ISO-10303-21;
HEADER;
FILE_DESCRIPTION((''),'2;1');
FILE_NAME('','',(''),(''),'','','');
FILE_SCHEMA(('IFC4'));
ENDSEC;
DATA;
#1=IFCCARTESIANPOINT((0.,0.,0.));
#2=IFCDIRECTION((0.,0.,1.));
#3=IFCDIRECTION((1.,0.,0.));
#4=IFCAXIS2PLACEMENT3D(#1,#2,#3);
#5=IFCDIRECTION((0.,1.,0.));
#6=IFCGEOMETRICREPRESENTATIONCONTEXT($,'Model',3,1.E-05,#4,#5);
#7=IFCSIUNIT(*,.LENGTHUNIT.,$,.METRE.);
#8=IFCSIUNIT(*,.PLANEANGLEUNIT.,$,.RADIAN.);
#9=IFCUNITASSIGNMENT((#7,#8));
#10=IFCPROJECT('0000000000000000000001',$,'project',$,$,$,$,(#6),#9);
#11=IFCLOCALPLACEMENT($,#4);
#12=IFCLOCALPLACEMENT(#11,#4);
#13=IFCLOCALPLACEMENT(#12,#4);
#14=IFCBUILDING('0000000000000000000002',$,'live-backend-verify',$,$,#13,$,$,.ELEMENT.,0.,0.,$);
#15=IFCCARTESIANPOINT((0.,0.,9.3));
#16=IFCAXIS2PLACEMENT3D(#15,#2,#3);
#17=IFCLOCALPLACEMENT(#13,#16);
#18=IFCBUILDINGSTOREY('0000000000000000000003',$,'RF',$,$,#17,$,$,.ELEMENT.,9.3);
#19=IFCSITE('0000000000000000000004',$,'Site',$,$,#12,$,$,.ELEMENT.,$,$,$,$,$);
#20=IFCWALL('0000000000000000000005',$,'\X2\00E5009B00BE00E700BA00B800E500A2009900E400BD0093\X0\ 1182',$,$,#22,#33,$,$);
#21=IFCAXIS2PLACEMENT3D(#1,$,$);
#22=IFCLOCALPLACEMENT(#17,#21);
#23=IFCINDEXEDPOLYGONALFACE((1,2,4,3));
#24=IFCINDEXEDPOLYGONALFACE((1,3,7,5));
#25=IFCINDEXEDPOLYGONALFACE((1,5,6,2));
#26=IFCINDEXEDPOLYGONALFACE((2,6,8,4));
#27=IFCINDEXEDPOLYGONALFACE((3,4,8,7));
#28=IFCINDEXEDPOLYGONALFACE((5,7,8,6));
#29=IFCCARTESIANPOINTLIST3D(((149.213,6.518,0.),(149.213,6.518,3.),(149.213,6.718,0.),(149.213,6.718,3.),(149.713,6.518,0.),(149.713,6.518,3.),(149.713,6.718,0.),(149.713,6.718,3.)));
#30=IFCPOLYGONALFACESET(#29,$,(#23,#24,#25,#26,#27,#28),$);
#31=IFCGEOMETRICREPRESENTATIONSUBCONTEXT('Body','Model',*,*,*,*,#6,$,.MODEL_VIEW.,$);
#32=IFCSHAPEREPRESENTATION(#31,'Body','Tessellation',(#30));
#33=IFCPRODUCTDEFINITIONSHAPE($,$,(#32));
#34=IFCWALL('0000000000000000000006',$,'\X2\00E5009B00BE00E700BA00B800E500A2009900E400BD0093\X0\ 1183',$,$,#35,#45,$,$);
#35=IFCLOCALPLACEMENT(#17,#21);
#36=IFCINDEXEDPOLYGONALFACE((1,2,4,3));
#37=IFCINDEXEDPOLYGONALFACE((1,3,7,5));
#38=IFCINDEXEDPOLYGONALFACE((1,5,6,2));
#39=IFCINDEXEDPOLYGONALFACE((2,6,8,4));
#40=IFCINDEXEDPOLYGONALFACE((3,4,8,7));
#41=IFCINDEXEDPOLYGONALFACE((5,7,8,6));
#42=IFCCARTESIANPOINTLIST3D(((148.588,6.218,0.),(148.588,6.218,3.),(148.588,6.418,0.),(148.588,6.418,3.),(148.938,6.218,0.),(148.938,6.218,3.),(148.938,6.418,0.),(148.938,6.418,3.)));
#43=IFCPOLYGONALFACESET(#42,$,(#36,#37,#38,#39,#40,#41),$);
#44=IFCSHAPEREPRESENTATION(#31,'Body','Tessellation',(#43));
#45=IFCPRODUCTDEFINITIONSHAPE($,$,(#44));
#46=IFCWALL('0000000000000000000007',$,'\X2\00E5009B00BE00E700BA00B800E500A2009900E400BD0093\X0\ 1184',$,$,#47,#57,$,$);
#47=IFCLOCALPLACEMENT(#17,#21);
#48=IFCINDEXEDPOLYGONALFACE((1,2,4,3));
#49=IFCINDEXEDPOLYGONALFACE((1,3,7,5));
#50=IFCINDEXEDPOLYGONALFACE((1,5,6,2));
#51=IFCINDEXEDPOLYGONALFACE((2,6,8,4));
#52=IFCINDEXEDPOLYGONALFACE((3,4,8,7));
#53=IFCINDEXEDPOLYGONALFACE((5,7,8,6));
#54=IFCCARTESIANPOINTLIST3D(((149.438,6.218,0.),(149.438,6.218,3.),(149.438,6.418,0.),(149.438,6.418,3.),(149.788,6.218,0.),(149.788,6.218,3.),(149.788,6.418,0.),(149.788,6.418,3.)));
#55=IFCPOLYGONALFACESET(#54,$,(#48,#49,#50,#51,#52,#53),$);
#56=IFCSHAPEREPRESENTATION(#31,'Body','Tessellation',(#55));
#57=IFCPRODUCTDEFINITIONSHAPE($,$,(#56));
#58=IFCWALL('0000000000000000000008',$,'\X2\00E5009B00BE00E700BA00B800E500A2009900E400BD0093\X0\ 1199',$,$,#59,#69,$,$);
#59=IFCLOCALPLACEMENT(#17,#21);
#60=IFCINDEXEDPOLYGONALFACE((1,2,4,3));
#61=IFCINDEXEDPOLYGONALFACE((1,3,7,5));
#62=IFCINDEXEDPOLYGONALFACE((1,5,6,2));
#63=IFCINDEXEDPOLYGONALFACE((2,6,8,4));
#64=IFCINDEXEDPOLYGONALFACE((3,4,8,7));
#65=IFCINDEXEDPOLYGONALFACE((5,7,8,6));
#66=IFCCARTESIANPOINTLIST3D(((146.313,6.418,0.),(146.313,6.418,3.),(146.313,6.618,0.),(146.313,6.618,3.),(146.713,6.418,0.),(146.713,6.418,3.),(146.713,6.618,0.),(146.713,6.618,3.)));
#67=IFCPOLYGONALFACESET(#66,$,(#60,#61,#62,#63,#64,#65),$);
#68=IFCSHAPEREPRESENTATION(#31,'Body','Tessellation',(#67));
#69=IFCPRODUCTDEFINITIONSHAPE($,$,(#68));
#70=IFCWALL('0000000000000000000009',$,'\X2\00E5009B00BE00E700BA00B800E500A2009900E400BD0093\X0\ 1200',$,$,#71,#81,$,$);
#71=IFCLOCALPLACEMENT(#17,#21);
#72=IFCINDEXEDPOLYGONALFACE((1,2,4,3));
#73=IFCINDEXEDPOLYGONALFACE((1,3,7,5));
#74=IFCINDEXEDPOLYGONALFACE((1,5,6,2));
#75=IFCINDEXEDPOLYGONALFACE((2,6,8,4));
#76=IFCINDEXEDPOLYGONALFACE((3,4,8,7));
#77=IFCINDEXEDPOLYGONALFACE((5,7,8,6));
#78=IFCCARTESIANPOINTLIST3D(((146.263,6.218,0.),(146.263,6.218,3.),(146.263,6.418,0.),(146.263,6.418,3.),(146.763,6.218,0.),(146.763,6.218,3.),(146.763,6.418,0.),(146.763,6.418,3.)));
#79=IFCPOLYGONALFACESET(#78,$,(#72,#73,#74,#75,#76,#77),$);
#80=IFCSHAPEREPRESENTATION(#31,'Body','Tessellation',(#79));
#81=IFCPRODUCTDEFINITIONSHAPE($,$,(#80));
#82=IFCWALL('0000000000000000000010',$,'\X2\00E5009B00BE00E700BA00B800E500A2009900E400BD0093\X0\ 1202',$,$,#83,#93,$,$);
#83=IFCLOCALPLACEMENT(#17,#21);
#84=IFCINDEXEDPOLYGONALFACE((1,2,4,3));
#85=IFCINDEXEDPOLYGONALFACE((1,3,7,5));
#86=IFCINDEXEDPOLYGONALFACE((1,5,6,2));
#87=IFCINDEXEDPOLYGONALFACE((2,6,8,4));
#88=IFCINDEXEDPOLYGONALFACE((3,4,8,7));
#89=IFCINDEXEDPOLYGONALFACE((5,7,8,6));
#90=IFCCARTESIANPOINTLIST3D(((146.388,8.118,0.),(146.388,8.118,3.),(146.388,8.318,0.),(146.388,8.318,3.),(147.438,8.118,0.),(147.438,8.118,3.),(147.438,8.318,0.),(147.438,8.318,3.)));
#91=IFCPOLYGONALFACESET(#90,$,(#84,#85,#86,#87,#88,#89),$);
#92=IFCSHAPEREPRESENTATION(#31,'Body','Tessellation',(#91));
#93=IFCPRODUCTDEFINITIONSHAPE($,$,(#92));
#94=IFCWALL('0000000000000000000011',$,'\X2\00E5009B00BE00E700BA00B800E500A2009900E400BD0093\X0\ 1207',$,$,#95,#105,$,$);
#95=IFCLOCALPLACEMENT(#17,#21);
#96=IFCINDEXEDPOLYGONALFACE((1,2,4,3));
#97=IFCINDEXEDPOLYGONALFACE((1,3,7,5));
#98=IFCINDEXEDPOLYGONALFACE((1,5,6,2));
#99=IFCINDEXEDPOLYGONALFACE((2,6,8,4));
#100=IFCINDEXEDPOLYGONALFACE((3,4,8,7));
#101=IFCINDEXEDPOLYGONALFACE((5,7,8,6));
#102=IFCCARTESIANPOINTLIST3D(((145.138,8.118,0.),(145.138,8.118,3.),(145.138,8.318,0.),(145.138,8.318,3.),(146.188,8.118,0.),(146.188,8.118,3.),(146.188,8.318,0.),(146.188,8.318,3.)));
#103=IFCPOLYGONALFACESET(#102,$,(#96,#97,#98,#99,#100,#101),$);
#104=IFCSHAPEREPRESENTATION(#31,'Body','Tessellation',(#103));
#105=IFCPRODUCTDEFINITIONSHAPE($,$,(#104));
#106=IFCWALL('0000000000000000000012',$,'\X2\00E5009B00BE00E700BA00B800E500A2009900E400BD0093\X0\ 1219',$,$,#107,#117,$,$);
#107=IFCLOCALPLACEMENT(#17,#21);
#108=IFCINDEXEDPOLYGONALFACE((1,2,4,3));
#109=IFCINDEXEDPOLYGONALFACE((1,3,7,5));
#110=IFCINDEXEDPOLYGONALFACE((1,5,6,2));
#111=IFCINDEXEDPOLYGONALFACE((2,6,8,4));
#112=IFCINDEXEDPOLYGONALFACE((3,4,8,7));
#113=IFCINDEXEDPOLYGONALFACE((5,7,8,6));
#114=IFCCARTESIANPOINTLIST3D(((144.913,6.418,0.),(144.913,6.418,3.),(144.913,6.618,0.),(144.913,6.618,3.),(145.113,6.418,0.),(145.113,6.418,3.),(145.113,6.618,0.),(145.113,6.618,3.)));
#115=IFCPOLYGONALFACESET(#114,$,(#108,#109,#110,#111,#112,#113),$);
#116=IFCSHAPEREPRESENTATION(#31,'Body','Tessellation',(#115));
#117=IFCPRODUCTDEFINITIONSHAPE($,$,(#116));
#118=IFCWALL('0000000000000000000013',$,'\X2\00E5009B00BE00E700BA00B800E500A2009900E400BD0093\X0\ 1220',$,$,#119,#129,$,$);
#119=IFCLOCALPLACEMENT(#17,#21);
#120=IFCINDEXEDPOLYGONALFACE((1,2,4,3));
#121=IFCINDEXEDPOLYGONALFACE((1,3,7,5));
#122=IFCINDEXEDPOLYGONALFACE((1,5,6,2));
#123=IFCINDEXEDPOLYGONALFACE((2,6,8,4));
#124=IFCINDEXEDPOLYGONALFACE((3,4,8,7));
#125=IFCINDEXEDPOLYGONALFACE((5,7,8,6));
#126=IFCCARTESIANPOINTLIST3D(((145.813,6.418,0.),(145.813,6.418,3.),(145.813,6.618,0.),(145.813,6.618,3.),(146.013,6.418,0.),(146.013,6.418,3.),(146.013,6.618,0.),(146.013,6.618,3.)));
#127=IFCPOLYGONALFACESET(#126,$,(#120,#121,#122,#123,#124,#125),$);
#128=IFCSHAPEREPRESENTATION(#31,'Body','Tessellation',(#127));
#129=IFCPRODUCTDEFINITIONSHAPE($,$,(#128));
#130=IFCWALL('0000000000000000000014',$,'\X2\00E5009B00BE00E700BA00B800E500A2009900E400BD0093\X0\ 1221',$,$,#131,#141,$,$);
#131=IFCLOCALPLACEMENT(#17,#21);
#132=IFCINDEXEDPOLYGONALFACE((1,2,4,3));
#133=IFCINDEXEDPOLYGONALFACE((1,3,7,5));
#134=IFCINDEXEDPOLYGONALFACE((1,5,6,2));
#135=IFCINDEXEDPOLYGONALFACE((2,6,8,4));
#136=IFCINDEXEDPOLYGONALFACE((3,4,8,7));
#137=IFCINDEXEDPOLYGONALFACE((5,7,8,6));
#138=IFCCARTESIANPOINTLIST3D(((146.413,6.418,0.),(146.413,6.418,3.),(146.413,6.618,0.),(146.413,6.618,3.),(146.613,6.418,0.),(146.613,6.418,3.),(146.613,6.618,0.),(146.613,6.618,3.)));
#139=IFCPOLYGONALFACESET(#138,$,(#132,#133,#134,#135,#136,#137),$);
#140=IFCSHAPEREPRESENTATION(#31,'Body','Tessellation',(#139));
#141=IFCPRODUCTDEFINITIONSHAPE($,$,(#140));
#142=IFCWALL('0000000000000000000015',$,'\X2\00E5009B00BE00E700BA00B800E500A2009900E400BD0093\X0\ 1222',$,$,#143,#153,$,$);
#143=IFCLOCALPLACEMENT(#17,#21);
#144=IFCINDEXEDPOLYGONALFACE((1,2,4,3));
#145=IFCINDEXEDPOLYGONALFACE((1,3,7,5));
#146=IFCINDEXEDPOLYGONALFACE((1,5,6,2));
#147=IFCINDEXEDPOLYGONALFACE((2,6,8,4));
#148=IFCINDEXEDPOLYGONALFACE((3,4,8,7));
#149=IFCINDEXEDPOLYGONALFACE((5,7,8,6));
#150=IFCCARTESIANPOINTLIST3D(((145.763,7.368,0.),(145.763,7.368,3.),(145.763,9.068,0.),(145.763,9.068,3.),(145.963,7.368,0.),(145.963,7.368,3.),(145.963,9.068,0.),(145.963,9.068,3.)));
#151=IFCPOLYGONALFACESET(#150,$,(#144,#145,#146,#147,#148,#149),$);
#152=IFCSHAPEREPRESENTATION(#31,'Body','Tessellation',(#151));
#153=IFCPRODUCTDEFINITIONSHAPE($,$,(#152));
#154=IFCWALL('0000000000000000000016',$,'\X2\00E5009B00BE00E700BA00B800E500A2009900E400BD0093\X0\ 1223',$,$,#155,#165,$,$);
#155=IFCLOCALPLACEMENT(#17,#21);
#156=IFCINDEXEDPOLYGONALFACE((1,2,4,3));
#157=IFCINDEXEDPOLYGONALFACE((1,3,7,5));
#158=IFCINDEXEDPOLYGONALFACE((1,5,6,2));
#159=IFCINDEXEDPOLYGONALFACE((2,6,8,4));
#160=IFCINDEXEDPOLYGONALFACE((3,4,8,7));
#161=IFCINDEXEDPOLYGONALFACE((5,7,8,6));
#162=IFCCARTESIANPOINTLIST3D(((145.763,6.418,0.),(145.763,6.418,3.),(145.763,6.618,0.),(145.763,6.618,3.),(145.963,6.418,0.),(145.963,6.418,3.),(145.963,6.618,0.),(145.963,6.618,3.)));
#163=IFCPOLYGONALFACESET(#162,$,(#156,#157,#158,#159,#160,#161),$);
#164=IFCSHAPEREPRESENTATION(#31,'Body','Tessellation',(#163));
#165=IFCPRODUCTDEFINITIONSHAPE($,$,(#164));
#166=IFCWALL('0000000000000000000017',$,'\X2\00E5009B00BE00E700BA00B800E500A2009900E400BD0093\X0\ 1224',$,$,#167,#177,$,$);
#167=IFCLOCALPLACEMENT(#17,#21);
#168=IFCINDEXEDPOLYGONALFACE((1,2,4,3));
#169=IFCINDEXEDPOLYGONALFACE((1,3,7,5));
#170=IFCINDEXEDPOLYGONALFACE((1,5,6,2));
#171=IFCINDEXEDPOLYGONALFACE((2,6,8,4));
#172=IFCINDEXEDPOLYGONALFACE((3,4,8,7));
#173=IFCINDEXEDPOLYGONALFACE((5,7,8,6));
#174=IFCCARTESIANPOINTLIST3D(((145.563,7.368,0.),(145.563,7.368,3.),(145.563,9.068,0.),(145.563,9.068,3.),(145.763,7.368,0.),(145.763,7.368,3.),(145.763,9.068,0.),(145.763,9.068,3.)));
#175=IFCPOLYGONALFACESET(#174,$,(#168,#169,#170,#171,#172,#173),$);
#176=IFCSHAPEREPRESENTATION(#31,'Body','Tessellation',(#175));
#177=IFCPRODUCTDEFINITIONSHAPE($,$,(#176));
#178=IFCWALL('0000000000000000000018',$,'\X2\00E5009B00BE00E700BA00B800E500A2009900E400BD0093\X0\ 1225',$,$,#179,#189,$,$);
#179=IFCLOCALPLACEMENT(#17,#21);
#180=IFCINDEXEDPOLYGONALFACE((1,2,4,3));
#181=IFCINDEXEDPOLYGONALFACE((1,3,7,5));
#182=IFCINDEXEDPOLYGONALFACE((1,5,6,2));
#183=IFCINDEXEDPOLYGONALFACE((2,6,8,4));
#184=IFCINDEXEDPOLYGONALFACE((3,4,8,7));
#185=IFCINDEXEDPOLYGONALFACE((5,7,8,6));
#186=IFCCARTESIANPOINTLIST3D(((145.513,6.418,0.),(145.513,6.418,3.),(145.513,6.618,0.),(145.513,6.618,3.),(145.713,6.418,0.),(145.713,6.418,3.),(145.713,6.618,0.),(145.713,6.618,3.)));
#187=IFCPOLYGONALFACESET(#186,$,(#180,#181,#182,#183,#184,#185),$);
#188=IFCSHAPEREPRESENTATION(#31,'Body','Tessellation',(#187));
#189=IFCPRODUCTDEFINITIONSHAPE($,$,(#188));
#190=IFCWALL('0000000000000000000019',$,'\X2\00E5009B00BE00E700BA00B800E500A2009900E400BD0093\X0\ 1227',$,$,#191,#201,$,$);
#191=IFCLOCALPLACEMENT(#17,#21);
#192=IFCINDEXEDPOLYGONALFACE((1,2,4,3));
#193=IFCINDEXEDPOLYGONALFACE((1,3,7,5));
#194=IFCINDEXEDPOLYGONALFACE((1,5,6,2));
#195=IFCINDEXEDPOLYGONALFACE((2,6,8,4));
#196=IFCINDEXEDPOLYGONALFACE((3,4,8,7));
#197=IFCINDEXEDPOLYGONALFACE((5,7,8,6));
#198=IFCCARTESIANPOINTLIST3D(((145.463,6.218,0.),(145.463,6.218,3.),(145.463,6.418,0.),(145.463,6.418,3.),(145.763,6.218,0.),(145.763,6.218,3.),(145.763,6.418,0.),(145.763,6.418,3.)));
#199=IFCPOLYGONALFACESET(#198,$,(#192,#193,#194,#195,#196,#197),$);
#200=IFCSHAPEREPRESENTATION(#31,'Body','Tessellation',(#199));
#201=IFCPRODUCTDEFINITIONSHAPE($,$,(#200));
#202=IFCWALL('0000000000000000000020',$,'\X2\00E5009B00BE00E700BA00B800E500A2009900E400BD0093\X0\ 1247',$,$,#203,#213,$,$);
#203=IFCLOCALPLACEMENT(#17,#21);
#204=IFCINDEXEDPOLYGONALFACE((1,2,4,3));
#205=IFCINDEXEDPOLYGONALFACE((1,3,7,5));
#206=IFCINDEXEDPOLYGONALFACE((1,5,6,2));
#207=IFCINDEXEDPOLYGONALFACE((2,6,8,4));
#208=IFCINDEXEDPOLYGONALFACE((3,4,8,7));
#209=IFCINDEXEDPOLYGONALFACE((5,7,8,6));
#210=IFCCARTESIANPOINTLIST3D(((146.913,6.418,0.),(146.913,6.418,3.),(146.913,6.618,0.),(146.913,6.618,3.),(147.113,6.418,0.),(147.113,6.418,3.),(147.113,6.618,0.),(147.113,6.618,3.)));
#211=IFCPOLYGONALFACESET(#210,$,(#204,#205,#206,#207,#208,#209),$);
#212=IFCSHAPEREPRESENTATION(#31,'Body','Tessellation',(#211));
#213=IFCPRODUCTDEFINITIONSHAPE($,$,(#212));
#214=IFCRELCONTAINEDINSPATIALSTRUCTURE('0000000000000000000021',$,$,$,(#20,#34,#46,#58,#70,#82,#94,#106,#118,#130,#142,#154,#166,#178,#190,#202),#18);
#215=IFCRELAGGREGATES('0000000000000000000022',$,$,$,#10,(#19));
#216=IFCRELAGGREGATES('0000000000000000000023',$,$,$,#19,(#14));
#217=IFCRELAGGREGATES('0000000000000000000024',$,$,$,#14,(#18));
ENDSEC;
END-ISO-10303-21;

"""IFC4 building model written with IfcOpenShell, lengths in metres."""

from ifc_helpers import new_model, si_unit, direction, frame, frame_2d, origin_with_axes, place, context, subcontext, project, spatial, rectangle, extrude, element, save


model = new_model("IFC4")

# Units and contexts
model_context = context("Model", 3, precision=1e-05, world=origin_with_axes(), true_north=direction((0.0, 1.0, 0.0)))
body_context = subcontext(model_context, "Body", "Model", "MODEL_VIEW")
ifc_project = project(units=[si_unit("LENGTHUNIT", "METRE"), si_unit("PLANEANGLEUNIT", "RADIAN")], contexts=[model_context])

# Site, building, storey
placement = place(None, origin_with_axes())
site_placement = place(placement, origin_with_axes())
site = spatial("IfcSite", under=ifc_project, at=site_placement, Name="Site", CompositionType="ELEMENT")
building_placement = place(site_placement, origin_with_axes())
building = spatial("IfcBuilding", under=site, at=building_placement, Name="live-backend-verify", CompositionType="ELEMENT", ElevationOfRefHeight=0.0, ElevationOfTerrain=0.0)
storey_placement = place(building_placement, frame((0.0, 0.0, 9.3), z_axis=(0.0, 0.0, 1.0), x_axis=(1.0, 0.0, 0.0)))
storey = spatial("IfcBuildingStorey", under=building, at=storey_placement, Name="RF", CompositionType="ELEMENT", Elevation=9.3)

# Walls
wall_1_placement = place(storey_placement, frame((149.463, 6.618, 0.0), z_axis=(0.0, 0.0, 1.0), x_axis=(1.0, 0.0, 0.0)))
element("IfcWall", 1, at=wall_1_placement, inside=storey, Name="å\u009b¾çº¸å¢\u0099ä½\u0093 1182", context=body_context, shape_type="SweptSolid", body=[
    extrude(rectangle(XDim=0.5, YDim=0.2, at=frame_2d((0.0, 0.0), x_axis=(1.0, 0.0, 0.0))), frame((0.0, 0.0, 0.0), z_axis=(0.0, 0.0, 1.0)), (0.0, 0.0, 1.0), 3.0),
])
for number, where, z_axis, x_axis, name in (
    (2, (148.763, 6.318, 0.0), (0.0, 0.0, 1.0), (1.0, 0.0, 0.0), "å\u009b¾çº¸å¢\u0099ä½\u0093 1183"),
    (3, (149.613, 6.318, 0.0), (0.0, 0.0, 1.0), (1.0, 0.0, 0.0), "å\u009b¾çº¸å¢\u0099ä½\u0093 1184"),
):
    element("IfcWall", number, at=place(storey_placement, frame(where, z_axis=z_axis, x_axis=x_axis)), inside=storey, Name=name, context=body_context, shape_type="SweptSolid", body=[
        extrude(rectangle(XDim=0.35, YDim=0.2, at=frame_2d((0.0, 0.0), x_axis=(1.0, 0.0, 0.0))), frame((0.0, 0.0, 0.0), z_axis=(0.0, 0.0, 1.0)), (0.0, 0.0, 1.0), 3.0),
    ])
wall_2_placement = place(storey_placement, frame((146.513, 6.518, 0.0), z_axis=(0.0, 0.0, 1.0), x_axis=(1.0, 0.0, 0.0)))
element("IfcWall", 4, at=wall_2_placement, inside=storey, Name="å\u009b¾çº¸å¢\u0099ä½\u0093 1199", context=body_context, shape_type="SweptSolid", body=[
    extrude(rectangle(XDim=0.4, YDim=0.2, at=frame_2d((0.0, 0.0), x_axis=(1.0, 0.0, 0.0))), frame((0.0, 0.0, 0.0), z_axis=(0.0, 0.0, 1.0)), (0.0, 0.0, 1.0), 3.0),
])
wall_3_placement = place(storey_placement, frame((146.513, 6.318, 0.0), z_axis=(0.0, 0.0, 1.0), x_axis=(1.0, 0.0, 0.0)))
element("IfcWall", 5, at=wall_3_placement, inside=storey, Name="å\u009b¾çº¸å¢\u0099ä½\u0093 1200", context=body_context, shape_type="SweptSolid", body=[
    extrude(rectangle(XDim=0.5, YDim=0.2, at=frame_2d((0.0, 0.0), x_axis=(1.0, 0.0, 0.0))), frame((0.0, 0.0, 0.0), z_axis=(0.0, 0.0, 1.0)), (0.0, 0.0, 1.0), 3.0),
])
for number, where, z_axis, x_axis, name in (
    (6, (146.913, 8.218, 0.0), (0.0, 0.0, 1.0), (-1.0, 0.0, 0.0), "å\u009b¾çº¸å¢\u0099ä½\u0093 1202"),
    (7, (145.663, 8.218, 0.0), (0.0, 0.0, 1.0), (-1.0, 0.0, 0.0), "å\u009b¾çº¸å¢\u0099ä½\u0093 1207"),
):
    element("IfcWall", number, at=place(storey_placement, frame(where, z_axis=z_axis, x_axis=x_axis)), inside=storey, Name=name, context=body_context, shape_type="SweptSolid", body=[
        extrude(rectangle(XDim=1.05, YDim=0.2, at=frame_2d((0.0, 0.0), x_axis=(1.0, 0.0, 0.0))), frame((0.0, 0.0, 0.0), z_axis=(0.0, 0.0, 1.0)), (0.0, 0.0, 1.0), 3.0),
    ])
for number, where, z_axis, x_axis, name in (
    (8, (145.013, 6.518, 0.0), (0.0, 0.0, 1.0), (0.0, -1.0, 0.0), "å\u009b¾çº¸å¢\u0099ä½\u0093 1219"),
    (9, (145.913, 6.518, 0.0), (0.0, 0.0, 1.0), (0.0, -1.0, 0.0), "å\u009b¾çº¸å¢\u0099ä½\u0093 1220"),
    (10, (146.513, 6.518, 0.0), (0.0, 0.0, 1.0), (0.0, -1.0, 0.0), "å\u009b¾çº¸å¢\u0099ä½\u0093 1221"),
):
    element("IfcWall", number, at=place(storey_placement, frame(where, z_axis=z_axis, x_axis=x_axis)), inside=storey, Name=name, context=body_context, shape_type="SweptSolid", body=[
        extrude(rectangle(XDim=0.2, YDim=0.2, at=frame_2d((0.0, 0.0), x_axis=(1.0, 0.0, 0.0))), frame((0.0, 0.0, 0.0), z_axis=(0.0, 0.0, 1.0)), (0.0, 0.0, 1.0), 3.0),
    ])
wall_4_placement = place(storey_placement, frame((145.863, 8.218, 0.0), z_axis=(0.0, 0.0, 1.0), x_axis=(0.0, -1.0, 0.0)))
element("IfcWall", 11, at=wall_4_placement, inside=storey, Name="å\u009b¾çº¸å¢\u0099ä½\u0093 1222", context=body_context, shape_type="SweptSolid", body=[
    extrude(rectangle(XDim=1.7, YDim=0.2, at=frame_2d((0.0, 0.0), x_axis=(1.0, 0.0, 0.0))), frame((0.0, 0.0, 0.0), z_axis=(0.0, 0.0, 1.0)), (0.0, 0.0, 1.0), 3.0),
])
wall_5_placement = place(storey_placement, frame((145.863, 6.518, 0.0), z_axis=(0.0, 0.0, 1.0), x_axis=(1.0, 0.0, 0.0)))
element("IfcWall", 12, at=wall_5_placement, inside=storey, Name="å\u009b¾çº¸å¢\u0099ä½\u0093 1223", context=body_context, shape_type="SweptSolid", body=[
    extrude(rectangle(XDim=0.2, YDim=0.2, at=frame_2d((0.0, 0.0), x_axis=(1.0, 0.0, 0.0))), frame((0.0, 0.0, 0.0), z_axis=(0.0, 0.0, 1.0)), (0.0, 0.0, 1.0), 3.0),
])
wall_6_placement = place(storey_placement, frame((145.663, 8.218, 0.0), z_axis=(0.0, 0.0, 1.0), x_axis=(0.0, -1.0, 0.0)))
element("IfcWall", 13, at=wall_6_placement, inside=storey, Name="å\u009b¾çº¸å¢\u0099ä½\u0093 1224", context=body_context, shape_type="SweptSolid", body=[
    extrude(rectangle(XDim=1.7, YDim=0.2, at=frame_2d((0.0, 0.0), x_axis=(1.0, 0.0, 0.0))), frame((0.0, 0.0, 0.0), z_axis=(0.0, 0.0, 1.0)), (0.0, 0.0, 1.0), 3.0),
])
for number, where, z_axis, x_axis, name in (
    (14, (145.613, 6.518, 0.0), (0.0, 0.0, 1.0), (1.0, 0.0, 0.0), "å\u009b¾çº¸å¢\u0099ä½\u0093 1225"),
):
    element("IfcWall", number, at=place(storey_placement, frame(where, z_axis=z_axis, x_axis=x_axis)), inside=storey, Name=name, context=body_context, shape_type="SweptSolid", body=[
        extrude(rectangle(XDim=0.2, YDim=0.2, at=frame_2d((0.0, 0.0), x_axis=(1.0, 0.0, 0.0))), frame((0.0, 0.0, 0.0), z_axis=(0.0, 0.0, 1.0)), (0.0, 0.0, 1.0), 3.0),
    ])
wall_7_placement = place(storey_placement, frame((145.613, 6.318, 0.0), z_axis=(0.0, 0.0, 1.0), x_axis=(1.0, 0.0, 0.0)))
element("IfcWall", 15, at=wall_7_placement, inside=storey, Name="å\u009b¾çº¸å¢\u0099ä½\u0093 1227", context=body_context, shape_type="SweptSolid", body=[
    extrude(rectangle(XDim=0.3, YDim=0.2, at=frame_2d((0.0, 0.0), x_axis=(1.0, 0.0, 0.0))), frame((0.0, 0.0, 0.0), z_axis=(0.0, 0.0, 1.0)), (0.0, 0.0, 1.0), 3.0),
])
for number, where, z_axis, x_axis, name in (
    (16, (147.013, 6.518, 0.0), (0.0, 0.0, 1.0), (0.0, -1.0, 0.0), "å\u009b¾çº¸å¢\u0099ä½\u0093 1247"),
):
    element("IfcWall", number, at=place(storey_placement, frame(where, z_axis=z_axis, x_axis=x_axis)), inside=storey, Name=name, context=body_context, shape_type="SweptSolid", body=[
        extrude(rectangle(XDim=0.2, YDim=0.2, at=frame_2d((0.0, 0.0), x_axis=(1.0, 0.0, 0.0))), frame((0.0, 0.0, 0.0), z_axis=(0.0, 0.0, 1.0)), (0.0, 0.0, 1.0), 3.0),
    ])

save(model, "model.ifc")
